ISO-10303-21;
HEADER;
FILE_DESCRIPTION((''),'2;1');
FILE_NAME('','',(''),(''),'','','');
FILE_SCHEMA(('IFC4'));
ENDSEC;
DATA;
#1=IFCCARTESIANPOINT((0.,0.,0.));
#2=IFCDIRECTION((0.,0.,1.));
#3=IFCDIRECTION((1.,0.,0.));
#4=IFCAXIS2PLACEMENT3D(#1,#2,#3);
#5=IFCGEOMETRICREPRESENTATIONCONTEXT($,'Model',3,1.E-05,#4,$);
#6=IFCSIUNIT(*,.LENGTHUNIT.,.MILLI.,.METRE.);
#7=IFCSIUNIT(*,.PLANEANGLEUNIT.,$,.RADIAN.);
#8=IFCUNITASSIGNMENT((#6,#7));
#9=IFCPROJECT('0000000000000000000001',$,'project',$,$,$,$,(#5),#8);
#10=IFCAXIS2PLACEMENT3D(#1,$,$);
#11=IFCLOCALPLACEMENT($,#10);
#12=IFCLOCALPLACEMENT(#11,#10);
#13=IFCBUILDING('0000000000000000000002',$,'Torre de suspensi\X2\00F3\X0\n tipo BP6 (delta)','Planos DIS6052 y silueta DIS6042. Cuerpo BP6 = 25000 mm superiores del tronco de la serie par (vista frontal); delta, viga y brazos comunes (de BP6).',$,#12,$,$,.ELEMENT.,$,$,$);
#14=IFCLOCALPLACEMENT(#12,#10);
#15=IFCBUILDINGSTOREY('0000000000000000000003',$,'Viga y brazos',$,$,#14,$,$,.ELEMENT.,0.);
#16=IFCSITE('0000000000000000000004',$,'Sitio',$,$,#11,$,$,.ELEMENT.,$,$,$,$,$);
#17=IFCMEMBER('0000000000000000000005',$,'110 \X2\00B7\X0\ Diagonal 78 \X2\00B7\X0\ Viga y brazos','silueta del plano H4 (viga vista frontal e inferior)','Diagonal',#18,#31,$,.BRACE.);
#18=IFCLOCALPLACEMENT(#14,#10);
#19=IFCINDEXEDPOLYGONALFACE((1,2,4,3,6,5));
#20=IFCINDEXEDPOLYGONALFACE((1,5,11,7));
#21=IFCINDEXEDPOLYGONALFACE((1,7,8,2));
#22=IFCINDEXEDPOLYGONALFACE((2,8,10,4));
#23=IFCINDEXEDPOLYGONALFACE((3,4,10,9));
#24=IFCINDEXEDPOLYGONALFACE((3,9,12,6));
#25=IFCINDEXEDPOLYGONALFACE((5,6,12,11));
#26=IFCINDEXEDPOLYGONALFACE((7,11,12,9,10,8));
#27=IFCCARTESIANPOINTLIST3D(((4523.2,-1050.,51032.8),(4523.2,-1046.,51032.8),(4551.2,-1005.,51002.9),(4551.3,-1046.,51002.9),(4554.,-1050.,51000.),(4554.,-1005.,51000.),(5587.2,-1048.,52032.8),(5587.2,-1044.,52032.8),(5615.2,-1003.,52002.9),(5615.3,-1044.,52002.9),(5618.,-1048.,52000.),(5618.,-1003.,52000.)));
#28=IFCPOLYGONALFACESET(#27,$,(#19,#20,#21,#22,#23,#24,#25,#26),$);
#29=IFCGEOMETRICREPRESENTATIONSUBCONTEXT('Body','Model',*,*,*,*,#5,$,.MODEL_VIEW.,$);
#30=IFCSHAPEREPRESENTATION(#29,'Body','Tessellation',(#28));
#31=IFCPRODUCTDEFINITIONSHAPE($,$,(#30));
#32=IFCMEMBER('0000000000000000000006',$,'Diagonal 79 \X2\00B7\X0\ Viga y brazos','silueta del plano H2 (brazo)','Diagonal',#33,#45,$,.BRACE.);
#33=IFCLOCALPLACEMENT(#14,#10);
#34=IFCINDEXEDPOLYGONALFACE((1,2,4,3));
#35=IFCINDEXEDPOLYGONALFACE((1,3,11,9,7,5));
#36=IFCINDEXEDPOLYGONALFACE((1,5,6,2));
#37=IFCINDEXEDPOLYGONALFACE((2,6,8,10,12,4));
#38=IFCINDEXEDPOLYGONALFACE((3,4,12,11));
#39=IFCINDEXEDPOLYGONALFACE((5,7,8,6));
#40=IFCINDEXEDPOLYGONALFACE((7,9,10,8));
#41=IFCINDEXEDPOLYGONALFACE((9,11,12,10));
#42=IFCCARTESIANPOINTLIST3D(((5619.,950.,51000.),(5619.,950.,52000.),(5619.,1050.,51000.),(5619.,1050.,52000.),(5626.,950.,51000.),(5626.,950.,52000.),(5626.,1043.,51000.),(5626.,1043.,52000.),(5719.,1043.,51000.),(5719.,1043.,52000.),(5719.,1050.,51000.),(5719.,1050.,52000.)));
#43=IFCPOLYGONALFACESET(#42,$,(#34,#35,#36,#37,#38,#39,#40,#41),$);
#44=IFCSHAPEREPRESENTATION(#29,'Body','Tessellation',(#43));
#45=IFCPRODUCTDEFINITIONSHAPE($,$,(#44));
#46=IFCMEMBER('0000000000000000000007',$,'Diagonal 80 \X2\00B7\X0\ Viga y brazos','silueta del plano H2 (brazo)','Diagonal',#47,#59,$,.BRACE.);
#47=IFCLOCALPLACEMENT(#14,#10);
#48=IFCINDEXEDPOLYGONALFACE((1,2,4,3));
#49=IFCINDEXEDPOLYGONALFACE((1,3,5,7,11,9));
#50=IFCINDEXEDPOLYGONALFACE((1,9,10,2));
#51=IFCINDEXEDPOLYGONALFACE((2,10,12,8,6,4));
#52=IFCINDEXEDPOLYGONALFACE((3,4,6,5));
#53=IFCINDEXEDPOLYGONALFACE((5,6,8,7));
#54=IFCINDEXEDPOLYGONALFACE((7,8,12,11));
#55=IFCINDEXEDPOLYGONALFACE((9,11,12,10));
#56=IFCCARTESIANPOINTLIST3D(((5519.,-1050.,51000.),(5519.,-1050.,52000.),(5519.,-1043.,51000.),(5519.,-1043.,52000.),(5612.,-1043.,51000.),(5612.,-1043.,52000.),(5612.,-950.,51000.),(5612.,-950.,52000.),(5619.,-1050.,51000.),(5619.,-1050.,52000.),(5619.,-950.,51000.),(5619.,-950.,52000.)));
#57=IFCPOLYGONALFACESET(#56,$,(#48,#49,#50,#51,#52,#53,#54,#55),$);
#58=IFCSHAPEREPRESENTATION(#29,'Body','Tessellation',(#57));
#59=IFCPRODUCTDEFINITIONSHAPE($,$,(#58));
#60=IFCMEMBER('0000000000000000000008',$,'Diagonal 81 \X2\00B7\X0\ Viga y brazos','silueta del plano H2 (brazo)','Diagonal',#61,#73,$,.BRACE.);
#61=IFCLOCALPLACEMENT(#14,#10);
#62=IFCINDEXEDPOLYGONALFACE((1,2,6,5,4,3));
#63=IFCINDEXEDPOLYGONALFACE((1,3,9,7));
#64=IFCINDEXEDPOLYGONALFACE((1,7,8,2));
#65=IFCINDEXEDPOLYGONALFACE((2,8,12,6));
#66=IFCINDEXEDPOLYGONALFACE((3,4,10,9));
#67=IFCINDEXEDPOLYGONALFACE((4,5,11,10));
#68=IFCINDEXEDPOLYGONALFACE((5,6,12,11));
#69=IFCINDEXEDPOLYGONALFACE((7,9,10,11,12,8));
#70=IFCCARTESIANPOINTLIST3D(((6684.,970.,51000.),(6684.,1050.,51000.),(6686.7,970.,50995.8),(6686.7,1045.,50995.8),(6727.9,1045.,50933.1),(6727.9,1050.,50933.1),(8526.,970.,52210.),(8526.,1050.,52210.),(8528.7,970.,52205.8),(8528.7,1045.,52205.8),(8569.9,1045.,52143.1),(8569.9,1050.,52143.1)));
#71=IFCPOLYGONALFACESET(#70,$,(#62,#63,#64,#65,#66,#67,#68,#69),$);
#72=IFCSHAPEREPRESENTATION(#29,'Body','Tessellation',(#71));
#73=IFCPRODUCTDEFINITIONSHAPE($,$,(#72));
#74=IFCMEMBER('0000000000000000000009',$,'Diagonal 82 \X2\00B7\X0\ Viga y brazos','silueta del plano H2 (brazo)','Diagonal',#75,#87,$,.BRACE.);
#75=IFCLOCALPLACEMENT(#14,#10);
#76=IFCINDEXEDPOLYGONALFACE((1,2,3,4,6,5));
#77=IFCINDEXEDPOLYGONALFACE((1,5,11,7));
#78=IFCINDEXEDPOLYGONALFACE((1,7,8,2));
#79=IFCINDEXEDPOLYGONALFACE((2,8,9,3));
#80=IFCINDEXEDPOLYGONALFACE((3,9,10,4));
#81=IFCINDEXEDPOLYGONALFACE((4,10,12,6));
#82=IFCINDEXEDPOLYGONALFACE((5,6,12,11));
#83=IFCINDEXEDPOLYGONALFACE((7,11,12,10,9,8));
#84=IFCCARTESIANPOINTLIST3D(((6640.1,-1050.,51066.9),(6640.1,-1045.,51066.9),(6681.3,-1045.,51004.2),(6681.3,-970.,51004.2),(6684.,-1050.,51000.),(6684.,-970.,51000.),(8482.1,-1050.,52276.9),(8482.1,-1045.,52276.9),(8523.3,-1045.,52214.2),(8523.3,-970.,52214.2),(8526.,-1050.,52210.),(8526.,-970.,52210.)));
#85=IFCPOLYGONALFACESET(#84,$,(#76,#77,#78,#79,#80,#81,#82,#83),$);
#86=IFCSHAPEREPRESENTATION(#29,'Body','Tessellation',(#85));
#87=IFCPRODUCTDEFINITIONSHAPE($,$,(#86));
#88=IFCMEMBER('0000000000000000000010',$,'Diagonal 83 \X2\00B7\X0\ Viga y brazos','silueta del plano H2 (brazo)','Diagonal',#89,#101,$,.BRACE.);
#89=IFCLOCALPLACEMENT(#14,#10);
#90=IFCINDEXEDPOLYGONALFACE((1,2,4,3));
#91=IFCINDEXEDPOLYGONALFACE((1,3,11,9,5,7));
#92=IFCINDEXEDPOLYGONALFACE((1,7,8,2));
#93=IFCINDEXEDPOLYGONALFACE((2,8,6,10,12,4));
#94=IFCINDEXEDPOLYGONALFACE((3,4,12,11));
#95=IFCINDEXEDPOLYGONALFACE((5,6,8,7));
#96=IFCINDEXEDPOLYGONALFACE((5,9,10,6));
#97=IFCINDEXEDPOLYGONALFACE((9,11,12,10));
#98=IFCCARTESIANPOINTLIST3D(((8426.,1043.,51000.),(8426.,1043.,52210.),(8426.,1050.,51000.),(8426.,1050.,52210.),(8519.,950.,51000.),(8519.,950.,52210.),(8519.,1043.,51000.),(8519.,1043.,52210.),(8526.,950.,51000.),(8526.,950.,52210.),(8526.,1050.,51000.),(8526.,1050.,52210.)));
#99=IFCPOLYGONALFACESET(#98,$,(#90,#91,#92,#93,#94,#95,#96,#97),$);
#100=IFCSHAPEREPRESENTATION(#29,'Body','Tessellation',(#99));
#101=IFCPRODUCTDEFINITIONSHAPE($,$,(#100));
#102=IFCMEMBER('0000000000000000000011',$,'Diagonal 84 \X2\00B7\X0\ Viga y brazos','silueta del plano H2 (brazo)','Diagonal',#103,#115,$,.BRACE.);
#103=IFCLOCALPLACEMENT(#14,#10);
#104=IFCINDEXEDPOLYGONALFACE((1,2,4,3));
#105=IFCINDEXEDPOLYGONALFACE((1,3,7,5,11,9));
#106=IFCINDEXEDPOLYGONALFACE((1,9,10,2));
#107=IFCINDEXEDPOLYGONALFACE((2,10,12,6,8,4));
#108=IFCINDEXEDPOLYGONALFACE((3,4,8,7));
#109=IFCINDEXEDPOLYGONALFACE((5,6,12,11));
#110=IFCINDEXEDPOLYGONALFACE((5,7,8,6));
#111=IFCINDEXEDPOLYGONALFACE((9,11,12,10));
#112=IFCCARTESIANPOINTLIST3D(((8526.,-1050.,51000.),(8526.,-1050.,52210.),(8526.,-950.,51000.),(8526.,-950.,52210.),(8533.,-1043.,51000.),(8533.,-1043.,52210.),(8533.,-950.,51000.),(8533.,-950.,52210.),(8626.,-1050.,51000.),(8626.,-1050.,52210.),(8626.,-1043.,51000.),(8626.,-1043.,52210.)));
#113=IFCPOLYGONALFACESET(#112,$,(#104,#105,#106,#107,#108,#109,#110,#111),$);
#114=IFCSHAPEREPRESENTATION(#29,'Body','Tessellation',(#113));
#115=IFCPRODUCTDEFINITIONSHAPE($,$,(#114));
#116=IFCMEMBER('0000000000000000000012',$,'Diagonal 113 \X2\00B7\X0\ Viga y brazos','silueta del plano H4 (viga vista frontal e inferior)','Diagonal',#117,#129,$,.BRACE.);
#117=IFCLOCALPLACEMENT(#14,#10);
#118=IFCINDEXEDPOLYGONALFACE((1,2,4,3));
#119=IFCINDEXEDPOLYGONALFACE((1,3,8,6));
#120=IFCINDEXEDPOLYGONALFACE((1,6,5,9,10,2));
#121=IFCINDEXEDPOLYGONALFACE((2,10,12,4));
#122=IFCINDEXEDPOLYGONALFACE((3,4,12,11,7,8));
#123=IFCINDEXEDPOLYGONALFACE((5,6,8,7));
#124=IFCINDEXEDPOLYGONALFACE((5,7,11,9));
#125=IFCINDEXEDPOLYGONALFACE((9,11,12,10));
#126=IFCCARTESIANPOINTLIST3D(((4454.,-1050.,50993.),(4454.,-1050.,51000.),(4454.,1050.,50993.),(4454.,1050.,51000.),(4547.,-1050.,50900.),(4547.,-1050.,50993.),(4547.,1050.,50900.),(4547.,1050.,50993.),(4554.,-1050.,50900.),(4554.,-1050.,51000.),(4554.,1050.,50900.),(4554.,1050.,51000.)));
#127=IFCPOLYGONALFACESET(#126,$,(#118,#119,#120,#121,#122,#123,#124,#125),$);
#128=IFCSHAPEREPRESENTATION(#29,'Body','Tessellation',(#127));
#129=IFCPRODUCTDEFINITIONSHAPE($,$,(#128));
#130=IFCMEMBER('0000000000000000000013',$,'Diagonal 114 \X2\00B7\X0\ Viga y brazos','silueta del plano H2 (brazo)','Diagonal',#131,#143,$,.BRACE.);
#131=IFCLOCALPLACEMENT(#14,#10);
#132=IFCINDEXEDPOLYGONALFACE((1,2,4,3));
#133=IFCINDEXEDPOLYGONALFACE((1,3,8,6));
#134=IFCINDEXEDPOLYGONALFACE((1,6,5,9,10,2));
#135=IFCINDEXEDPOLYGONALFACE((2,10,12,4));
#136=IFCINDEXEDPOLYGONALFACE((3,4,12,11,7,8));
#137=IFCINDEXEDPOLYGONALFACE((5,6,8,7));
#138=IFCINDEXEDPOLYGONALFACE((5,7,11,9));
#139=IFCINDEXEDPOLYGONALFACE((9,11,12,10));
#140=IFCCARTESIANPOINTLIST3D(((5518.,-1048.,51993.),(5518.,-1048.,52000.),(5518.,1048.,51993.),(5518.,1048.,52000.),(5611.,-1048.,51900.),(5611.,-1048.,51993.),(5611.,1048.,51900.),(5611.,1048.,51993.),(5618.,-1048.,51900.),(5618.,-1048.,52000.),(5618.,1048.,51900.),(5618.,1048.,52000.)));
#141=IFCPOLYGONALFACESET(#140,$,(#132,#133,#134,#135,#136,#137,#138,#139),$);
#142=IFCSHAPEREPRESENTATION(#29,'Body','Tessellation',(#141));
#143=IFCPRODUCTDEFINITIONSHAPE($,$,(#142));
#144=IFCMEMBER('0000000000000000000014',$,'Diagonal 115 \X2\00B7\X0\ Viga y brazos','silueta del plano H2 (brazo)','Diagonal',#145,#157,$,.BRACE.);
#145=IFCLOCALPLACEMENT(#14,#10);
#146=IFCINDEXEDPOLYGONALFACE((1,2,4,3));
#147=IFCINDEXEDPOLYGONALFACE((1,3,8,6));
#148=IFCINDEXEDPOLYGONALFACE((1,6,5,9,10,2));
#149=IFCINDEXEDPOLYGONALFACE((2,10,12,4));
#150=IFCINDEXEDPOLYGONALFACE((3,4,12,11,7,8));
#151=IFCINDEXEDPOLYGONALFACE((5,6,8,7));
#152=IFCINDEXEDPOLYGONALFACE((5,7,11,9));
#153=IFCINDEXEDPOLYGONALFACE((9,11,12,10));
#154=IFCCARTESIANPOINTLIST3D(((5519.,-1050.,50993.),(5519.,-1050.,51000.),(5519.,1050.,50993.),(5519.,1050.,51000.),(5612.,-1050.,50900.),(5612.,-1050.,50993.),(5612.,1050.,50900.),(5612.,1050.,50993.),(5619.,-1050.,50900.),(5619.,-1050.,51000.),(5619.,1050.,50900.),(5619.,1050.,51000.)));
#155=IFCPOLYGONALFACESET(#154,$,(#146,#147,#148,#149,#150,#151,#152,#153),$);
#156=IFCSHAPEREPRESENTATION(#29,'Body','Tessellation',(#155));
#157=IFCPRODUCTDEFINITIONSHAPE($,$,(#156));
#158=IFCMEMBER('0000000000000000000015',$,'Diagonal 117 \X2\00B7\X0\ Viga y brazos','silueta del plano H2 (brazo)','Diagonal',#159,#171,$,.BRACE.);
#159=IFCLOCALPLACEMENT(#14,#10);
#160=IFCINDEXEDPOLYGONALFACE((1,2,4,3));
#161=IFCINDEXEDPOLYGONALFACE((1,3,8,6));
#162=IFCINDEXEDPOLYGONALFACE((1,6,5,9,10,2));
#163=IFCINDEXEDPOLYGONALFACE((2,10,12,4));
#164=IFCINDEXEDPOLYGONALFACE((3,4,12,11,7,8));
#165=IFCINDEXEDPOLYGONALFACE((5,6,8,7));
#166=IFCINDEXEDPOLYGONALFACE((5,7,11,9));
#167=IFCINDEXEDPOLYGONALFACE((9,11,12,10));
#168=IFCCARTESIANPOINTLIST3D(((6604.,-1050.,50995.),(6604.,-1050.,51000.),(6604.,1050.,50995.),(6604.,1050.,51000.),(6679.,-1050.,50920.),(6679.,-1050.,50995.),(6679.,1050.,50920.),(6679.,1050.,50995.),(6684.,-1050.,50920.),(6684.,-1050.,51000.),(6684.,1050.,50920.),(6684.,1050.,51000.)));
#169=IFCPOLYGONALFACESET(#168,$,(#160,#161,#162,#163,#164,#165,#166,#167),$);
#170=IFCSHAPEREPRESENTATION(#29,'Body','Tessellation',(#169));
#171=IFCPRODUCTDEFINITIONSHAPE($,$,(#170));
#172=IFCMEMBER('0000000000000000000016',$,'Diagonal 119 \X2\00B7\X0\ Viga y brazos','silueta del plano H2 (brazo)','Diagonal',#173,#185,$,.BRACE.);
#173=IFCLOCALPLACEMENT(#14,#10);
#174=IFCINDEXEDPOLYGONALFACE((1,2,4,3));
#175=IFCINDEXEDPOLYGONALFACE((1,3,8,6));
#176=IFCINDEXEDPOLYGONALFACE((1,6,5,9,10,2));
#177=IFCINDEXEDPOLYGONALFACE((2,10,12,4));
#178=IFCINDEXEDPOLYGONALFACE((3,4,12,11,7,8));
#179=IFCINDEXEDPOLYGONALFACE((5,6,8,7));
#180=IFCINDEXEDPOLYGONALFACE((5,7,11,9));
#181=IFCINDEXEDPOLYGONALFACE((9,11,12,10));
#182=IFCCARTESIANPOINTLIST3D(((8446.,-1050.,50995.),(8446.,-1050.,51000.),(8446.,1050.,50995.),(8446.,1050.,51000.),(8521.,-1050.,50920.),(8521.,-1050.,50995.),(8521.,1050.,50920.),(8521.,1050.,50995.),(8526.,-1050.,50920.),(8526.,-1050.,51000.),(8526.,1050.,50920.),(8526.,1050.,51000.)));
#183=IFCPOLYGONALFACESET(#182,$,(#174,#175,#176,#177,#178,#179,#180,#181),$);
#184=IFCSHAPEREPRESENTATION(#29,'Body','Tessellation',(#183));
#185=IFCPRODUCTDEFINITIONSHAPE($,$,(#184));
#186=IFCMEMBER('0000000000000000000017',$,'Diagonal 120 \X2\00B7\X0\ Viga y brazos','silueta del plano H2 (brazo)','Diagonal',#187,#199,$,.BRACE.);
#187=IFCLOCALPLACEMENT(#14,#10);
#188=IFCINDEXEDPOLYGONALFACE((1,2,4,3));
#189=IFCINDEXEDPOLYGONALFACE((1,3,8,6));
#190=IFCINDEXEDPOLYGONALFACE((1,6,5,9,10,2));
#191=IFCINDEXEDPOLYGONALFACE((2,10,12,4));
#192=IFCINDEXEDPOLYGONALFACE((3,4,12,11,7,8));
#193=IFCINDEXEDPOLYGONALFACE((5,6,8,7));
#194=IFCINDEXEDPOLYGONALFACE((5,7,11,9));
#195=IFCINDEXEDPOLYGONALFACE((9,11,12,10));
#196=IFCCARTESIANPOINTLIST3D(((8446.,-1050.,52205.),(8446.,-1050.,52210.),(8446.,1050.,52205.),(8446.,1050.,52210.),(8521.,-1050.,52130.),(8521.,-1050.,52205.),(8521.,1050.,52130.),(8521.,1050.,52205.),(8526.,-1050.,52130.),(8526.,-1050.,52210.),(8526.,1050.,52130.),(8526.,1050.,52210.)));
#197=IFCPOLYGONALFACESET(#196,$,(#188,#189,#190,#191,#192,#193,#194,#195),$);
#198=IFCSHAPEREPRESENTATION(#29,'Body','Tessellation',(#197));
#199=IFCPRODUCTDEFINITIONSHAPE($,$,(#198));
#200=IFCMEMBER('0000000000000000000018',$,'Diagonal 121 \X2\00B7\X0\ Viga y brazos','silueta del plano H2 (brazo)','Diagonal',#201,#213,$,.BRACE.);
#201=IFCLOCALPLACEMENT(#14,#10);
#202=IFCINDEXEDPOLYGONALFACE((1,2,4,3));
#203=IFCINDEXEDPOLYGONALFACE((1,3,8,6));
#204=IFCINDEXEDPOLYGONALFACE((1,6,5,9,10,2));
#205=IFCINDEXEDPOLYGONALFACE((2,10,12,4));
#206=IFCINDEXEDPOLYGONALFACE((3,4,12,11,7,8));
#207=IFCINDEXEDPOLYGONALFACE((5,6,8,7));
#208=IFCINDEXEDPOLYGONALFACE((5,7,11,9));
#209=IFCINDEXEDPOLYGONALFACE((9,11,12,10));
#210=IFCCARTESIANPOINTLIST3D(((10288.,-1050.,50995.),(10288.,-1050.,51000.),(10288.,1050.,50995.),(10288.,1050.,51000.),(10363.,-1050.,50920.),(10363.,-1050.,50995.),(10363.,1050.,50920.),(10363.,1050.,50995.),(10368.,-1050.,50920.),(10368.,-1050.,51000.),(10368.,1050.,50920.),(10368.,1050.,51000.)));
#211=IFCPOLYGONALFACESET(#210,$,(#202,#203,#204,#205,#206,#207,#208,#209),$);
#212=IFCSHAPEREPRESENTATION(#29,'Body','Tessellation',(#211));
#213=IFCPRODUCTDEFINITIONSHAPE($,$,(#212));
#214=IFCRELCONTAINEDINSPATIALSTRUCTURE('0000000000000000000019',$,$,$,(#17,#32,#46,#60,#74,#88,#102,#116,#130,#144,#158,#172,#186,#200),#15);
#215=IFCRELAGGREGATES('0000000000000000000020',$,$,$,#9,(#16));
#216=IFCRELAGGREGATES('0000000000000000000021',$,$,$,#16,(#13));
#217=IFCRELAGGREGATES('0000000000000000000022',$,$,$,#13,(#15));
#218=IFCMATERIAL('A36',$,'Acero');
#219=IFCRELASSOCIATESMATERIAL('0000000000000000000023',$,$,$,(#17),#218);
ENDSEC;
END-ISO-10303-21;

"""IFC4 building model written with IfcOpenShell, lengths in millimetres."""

from ifc_helpers import new_model, si_unit, frame, frame_2d, origin, origin_with_axes, place, context, subcontext, project, spatial, l_section, extrude, material, element, save


model = new_model("IFC4")

# Units and contexts
model_context = context("Model", 3, precision=1e-05, world=origin_with_axes())
body_context = subcontext(model_context, "Body", "Model", "MODEL_VIEW")
ifc_project = project(units=[si_unit("LENGTHUNIT", "METRE", prefix="MILLI"), si_unit("PLANEANGLEUNIT", "RADIAN")], contexts=[model_context])

# Site, building, storey
site_placement = place(None, origin())
site = spatial("IfcSite", under=ifc_project, at=site_placement, Name="Sitio", CompositionType="ELEMENT")
building_placement = place(site_placement, origin())
building = spatial("IfcBuilding", under=site, at=building_placement, Name="Torre de suspensión tipo BP6 (delta)", Description="Planos DIS6052 y silueta DIS6042. Cuerpo BP6 = 25000 mm superiores del tronco de la serie par (vista frontal); delta, viga y brazos comunes (de BP6).", CompositionType="ELEMENT")
storey_placement = place(building_placement, origin())
storey = spatial("IfcBuildingStorey", under=building, at=storey_placement, Name="Viga y brazos", CompositionType="ELEMENT", Elevation=0.0)

# Members
ifc_material_1 = material(Name="A36", Category="Acero")
for number, where, z_axis, x_axis, name in (
    (1, (4554.0, -1050.0, 51000.0), (0.728682, 0.00137, 0.684851), (-0.000998, 0.999999, -0.000938), "110 · Diagonal 78 · Viga y brazos"),
):
    element("IfcMember", number, at=place(storey_placement, frame(where, z_axis=z_axis, x_axis=x_axis)), inside=storey, material=ifc_material_1, Name=name, Description="silueta del plano H4 (viga vista frontal e inferior)", ObjectType="Diagonal", PredefinedType="BRACE", context=body_context, shape_type="SweptSolid", body=[
        extrude(l_section(Depth=45.0, Width=45.0, Thickness=4.0, at=frame_2d((22.5, 22.5))), None, (0.0, 0.0, 1.0), 1460.2),
    ])
for number, where, z_axis, x_axis, name in (
    (2, (5619.0, 1050.0, 51000.0), (0.0, 0.0, 1.0), (0.0, -1.0, 0.0), "Diagonal 79 · Viga y brazos"),
    (3, (5619.0, -1050.0, 51000.0), (0.0, 0.0, 1.0), (0.0, 1.0, 0.0), "Diagonal 80 · Viga y brazos"),
):
    element("IfcMember", number, at=place(storey_placement, frame(where, z_axis=z_axis, x_axis=x_axis)), inside=storey, Name=name, Description="silueta del plano H2 (brazo)", ObjectType="Diagonal", PredefinedType="BRACE", context=body_context, shape_type="SweptSolid", body=[
        extrude(l_section(Depth=100.0, Width=100.0, Thickness=7.0, at=frame_2d((50.0, 50.0))), None, (0.0, 0.0, 1.0), 1000.0),
    ])
for number, where, z_axis, x_axis, name in (
    (4, (6684.0, 1050.0, 51000.0), (0.835801, 0.0, 0.549033), (0.0, -1.0, 0.0), "Diagonal 81 · Viga y brazos"),
    (5, (6684.0, -1050.0, 51000.0), (0.835801, 0.0, 0.549033), (0.0, 1.0, 0.0), "Diagonal 82 · Viga y brazos"),
):
    element("IfcMember", number, at=place(storey_placement, frame(where, z_axis=z_axis, x_axis=x_axis)), inside=storey, Name=name, Description="silueta del plano H2 (brazo)", ObjectType="Diagonal", PredefinedType="BRACE", context=body_context, shape_type="SweptSolid", body=[
        extrude(l_section(Depth=80.0, Width=80.0, Thickness=5.0, at=frame_2d((40.0, 40.0))), None, (0.0, 0.0, 1.0), 2203.9),
    ])
for number, where, z_axis, x_axis, name in (
    (6, (8526.0, 1050.0, 52210.0), (0.0, 0.0, -1.0), (0.0, -1.0, 0.0), "Diagonal 83 · Viga y brazos"),
    (7, (8526.0, -1050.0, 52210.0), (0.0, 0.0, -1.0), (0.0, 1.0, 0.0), "Diagonal 84 · Viga y brazos"),
):
    element("IfcMember", number, at=place(storey_placement, frame(where, z_axis=z_axis, x_axis=x_axis)), inside=storey, Name=name, Description="silueta del plano H2 (brazo)", ObjectType="Diagonal", PredefinedType="BRACE", context=body_context, shape_type="SweptSolid", body=[
        extrude(l_section(Depth=100.0, Width=100.0, Thickness=7.0, at=frame_2d((50.0, 50.0))), None, (0.0, 0.0, 1.0), 1210.0),
    ])
member_1_placement = place(storey_placement, frame((4554.0, 1050.0, 51000.0), z_axis=(0.0, -1.0, 0.0), x_axis=(-1.0, 0.0, 0.0)))
element("IfcMember", 8, at=member_1_placement, inside=storey, Name="Diagonal 113 · Viga y brazos", Description="silueta del plano H4 (viga vista frontal e inferior)", ObjectType="Diagonal", PredefinedType="BRACE", context=body_context, shape_type="SweptSolid", body=[
    extrude(l_section(Depth=100.0, Width=100.0, Thickness=7.0, at=frame_2d((50.0, 50.0))), None, (0.0, 0.0, 1.0), 2100.0),
])
member_2_placement = place(storey_placement, frame((5618.0, 1048.0, 52000.0), z_axis=(0.0, -1.0, 0.0), x_axis=(-1.0, 0.0, 0.0)))
element("IfcMember", 9, at=member_2_placement, inside=storey, Name="Diagonal 114 · Viga y brazos", Description="silueta del plano H2 (brazo)", ObjectType="Diagonal", PredefinedType="BRACE", context=body_context, shape_type="SweptSolid", body=[
    extrude(l_section(Depth=100.0, Width=100.0, Thickness=7.0, at=frame_2d((50.0, 50.0))), None, (0.0, 0.0, 1.0), 2096.0),
])
member_3_placement = place(storey_placement, frame((5619.0, 1050.0, 51000.0), z_axis=(0.0, -1.0, 0.0), x_axis=(-1.0, 0.0, 0.0)))
element("IfcMember", 10, at=member_3_placement, inside=storey, Name="Diagonal 115 · Viga y brazos", Description="silueta del plano H2 (brazo)", ObjectType="Diagonal", PredefinedType="BRACE", context=body_context, shape_type="SweptSolid", body=[
    extrude(l_section(Depth=100.0, Width=100.0, Thickness=7.0, at=frame_2d((50.0, 50.0))), None, (0.0, 0.0, 1.0), 2100.0),
])
for number, where, z_axis, x_axis, name in (
    (11, (6684.0, 1050.0, 51000.0), (0.0, -1.0, 0.0), (-1.0, 0.0, 0.0), "Diagonal 117 · Viga y brazos"),
    (12, (8526.0, 1050.0, 51000.0), (0.0, -1.0, 0.0), (-1.0, 0.0, 0.0), "Diagonal 119 · Viga y brazos"),
    (13, (8526.0, 1050.0, 52210.0), (0.0, -1.0, 0.0), (-1.0, 0.0, 0.0), "Diagonal 120 · Viga y brazos"),
    (14, (10368.0, 1050.0, 51000.0), (0.0, -1.0, 0.0), (-1.0, 0.0, 0.0), "Diagonal 121 · Viga y brazos"),
):
    element("IfcMember", number, at=place(storey_placement, frame(where, z_axis=z_axis, x_axis=x_axis)), inside=storey, Name=name, Description="silueta del plano H2 (brazo)", ObjectType="Diagonal", PredefinedType="BRACE", context=body_context, shape_type="SweptSolid", body=[
        extrude(l_section(Depth=80.0, Width=80.0, Thickness=5.0, at=frame_2d((40.0, 40.0))), None, (0.0, 0.0, 1.0), 2100.0),
    ])

save(model, "model.ifc")
